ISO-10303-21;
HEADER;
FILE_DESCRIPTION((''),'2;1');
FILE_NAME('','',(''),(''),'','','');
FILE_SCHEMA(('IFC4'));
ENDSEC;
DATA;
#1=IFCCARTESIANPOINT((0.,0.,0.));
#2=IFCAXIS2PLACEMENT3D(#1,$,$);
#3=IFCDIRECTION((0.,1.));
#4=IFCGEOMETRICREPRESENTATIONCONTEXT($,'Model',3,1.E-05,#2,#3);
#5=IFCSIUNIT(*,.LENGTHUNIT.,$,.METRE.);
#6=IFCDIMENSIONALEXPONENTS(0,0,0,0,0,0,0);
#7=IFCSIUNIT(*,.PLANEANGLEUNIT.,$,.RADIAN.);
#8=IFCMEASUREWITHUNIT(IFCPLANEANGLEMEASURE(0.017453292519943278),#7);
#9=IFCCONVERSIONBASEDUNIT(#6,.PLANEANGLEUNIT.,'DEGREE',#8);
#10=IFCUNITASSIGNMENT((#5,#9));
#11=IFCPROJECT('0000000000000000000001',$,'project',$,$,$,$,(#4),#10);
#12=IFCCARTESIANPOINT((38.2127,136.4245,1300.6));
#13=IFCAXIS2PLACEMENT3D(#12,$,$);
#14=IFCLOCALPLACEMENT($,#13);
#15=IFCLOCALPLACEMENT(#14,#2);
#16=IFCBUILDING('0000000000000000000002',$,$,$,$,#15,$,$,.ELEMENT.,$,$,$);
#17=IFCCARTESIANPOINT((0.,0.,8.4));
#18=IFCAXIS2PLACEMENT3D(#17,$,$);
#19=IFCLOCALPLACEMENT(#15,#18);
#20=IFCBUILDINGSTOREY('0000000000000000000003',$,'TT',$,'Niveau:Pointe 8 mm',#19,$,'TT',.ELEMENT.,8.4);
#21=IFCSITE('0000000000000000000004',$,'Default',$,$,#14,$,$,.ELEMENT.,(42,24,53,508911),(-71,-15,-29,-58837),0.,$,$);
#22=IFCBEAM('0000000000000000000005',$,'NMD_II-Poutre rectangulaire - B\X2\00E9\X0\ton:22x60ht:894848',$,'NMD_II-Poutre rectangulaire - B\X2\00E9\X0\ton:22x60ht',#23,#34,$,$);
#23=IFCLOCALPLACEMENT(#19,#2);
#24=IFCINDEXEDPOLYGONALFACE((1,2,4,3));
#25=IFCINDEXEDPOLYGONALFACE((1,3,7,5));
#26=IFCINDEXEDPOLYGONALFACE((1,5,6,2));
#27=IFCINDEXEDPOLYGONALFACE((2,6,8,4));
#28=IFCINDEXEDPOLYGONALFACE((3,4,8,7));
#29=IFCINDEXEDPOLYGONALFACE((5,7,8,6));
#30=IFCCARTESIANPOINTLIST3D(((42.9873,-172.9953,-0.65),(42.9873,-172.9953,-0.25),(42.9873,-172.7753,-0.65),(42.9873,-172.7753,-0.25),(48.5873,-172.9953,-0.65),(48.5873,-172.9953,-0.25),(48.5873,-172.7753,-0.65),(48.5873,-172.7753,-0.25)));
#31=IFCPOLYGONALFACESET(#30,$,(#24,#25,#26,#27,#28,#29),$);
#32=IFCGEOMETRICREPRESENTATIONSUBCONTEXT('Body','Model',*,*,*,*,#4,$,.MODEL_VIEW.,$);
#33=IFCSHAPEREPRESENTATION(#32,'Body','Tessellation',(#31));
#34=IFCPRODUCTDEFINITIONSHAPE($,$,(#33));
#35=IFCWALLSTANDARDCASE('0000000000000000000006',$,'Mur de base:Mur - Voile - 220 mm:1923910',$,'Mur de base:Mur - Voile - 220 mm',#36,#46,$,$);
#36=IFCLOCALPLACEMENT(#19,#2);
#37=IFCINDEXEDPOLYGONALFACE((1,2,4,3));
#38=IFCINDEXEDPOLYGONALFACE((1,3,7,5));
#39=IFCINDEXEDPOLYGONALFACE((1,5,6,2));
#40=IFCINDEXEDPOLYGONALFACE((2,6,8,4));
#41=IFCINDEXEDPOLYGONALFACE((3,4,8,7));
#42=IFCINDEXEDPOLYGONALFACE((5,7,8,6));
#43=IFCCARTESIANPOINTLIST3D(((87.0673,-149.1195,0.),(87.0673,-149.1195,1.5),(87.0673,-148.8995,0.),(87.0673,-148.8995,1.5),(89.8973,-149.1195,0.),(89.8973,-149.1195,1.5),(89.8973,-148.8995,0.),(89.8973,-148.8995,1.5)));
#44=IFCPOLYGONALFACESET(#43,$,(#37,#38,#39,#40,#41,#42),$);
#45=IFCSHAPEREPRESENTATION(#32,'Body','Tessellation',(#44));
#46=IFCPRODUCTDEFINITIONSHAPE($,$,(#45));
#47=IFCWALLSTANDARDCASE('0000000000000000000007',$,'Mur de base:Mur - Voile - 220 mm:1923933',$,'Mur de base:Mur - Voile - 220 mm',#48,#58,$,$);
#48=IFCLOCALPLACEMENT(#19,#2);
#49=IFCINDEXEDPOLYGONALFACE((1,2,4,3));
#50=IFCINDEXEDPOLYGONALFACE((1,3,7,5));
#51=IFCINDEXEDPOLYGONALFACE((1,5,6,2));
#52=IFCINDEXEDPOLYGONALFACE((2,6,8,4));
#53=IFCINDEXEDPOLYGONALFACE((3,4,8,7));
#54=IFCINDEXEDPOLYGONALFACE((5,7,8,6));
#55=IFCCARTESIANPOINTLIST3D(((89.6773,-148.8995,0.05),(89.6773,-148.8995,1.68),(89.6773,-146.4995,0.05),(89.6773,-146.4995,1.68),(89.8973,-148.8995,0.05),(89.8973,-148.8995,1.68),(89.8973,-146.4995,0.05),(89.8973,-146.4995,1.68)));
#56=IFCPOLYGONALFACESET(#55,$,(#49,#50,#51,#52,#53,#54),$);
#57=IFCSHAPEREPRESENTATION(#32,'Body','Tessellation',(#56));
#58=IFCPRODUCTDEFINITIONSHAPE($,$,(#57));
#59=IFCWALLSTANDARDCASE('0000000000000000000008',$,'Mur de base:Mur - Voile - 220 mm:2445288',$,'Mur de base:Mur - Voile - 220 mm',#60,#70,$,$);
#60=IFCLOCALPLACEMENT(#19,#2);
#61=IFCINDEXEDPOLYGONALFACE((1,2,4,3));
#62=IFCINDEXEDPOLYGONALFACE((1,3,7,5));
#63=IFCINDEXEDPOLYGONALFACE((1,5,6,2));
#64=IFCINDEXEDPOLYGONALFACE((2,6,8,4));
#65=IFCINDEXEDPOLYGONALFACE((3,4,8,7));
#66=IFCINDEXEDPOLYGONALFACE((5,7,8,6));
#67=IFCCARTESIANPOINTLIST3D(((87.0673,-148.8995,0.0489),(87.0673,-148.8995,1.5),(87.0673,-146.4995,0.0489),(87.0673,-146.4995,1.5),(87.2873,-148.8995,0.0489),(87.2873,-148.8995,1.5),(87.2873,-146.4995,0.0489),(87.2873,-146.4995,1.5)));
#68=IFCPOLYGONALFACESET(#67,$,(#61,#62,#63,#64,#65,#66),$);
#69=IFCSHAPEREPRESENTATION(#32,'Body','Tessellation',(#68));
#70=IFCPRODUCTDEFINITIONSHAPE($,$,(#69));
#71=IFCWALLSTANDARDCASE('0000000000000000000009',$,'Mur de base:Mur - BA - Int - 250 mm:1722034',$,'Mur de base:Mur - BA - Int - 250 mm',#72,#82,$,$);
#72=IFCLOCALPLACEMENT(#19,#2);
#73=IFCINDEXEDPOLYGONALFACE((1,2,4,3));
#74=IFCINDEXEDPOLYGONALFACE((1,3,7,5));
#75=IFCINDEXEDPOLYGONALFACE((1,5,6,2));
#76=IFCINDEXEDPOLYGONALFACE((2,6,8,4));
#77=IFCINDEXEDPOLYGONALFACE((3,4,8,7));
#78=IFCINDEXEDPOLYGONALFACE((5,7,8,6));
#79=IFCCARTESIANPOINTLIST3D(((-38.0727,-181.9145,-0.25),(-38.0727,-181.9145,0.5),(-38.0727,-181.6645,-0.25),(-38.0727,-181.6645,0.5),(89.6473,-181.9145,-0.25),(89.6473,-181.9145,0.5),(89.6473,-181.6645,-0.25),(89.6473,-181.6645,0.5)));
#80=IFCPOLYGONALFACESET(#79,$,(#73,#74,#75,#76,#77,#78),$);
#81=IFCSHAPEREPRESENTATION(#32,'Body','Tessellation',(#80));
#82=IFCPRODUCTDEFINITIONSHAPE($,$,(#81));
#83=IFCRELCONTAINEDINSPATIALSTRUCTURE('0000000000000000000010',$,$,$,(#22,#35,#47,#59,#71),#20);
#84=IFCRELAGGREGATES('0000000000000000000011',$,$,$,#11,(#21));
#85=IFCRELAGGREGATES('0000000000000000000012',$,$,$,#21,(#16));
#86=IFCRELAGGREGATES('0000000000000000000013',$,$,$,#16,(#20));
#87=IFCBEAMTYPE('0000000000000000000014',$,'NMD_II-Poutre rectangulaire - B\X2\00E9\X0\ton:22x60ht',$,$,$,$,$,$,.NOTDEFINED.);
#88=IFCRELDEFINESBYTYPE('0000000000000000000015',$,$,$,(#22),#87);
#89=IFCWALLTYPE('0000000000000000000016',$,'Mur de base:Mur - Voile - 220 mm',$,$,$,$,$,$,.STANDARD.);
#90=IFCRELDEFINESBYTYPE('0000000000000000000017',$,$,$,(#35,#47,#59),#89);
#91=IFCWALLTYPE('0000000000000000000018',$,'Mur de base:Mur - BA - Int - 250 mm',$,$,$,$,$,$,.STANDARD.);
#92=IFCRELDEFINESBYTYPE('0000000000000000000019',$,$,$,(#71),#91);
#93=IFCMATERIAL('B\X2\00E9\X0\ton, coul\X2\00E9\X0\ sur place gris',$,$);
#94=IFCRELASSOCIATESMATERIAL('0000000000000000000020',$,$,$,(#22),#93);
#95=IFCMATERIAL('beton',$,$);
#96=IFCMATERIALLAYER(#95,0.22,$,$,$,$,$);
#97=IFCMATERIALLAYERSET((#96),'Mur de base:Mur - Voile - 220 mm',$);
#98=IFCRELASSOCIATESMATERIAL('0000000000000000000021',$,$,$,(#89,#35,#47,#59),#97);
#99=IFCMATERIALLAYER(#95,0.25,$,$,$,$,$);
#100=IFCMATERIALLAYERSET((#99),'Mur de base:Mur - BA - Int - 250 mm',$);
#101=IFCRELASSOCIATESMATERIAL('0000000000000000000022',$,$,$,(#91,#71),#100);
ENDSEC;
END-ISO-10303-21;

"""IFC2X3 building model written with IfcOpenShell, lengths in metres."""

from ifc_helpers import new_model, entity, si_unit, converted_unit, direction, frame, frame_2d, origin, origin_2d_with_axis, place, context, subcontext, project, spatial, polyline, rectangle, extrude, clip, bounded_halfspace, material, layer, layer_set, layer_usage, type_object, element, save


model = new_model("IFC2X3")

# Units and contexts
model_context = context("Model", 3, precision=1e-05, world=origin(), true_north=direction((0.0, 1.0)))
body_context = subcontext(model_context, "Body", "Model", "MODEL_VIEW")
ifc_project = project(units=[si_unit("LENGTHUNIT", "METRE"), converted_unit("PLANEANGLEUNIT", "DEGREE", entity("IfcPlaneAngleMeasure", 0.017453292519943278), si_unit("PLANEANGLEUNIT", "RADIAN"), dimensions=[0, 0, 0, 0, 0, 0, 0])], contexts=[model_context])

# Site, building, storey
site_placement = place(None, frame((38.2127, 136.4245, 1300.6)))
site = spatial("IfcSite", under=ifc_project, at=site_placement, Name="Default", CompositionType="ELEMENT", RefLatitude=(42, 24, 53, 508911), RefLongitude=(-71, -15, -29, -58837), RefElevation=0.0)
building_placement = place(site_placement, origin())
building = spatial("IfcBuilding", under=site, at=building_placement, CompositionType="ELEMENT")
storey_placement = place(building_placement, frame((0.0, 0.0, 8.4)))
storey = spatial("IfcBuildingStorey", under=building, at=storey_placement, Name="TT", ObjectType="Niveau:Pointe 8 mm", LongName="TT", CompositionType="ELEMENT", Elevation=8.4)

# Beam
ifc_material_1 = material(Name="Béton, coulé sur place gris")
beam_type_1 = type_object("IfcBeamType", Name="NMD_II-Poutre rectangulaire - Béton:22x60ht", PredefinedType="NOTDEFINED")
beam_1_placement = place(storey_placement, frame((42.9873, -172.8853, -0.05)))
element("IfcBeam", 1, at=beam_1_placement, inside=storey, type_object=beam_type_1, material=ifc_material_1, Name="NMD_II-Poutre rectangulaire - Béton:22x60ht:894848", ObjectType="NMD_II-Poutre rectangulaire - Béton:22x60ht", context=body_context, shape_type="SweptSolid", body=[
    extrude(rectangle(XDim=0.4, YDim=0.22, at=origin_2d_with_axis()), frame((0.0, 0.0, -0.4), z_axis=(1.0, 0.0, 0.0), x_axis=(0.0, 0.0, -1.0)), (0.0, 0.0, 1.0), 5.6),
])

# Walls
ifc_material_2 = material(Name="beton")
ifc_layer_1 = layer(ifc_material_2, 0.22)
ifc_layer_set_1 = layer_set([ifc_layer_1], Name="Mur de base:Mur - Voile - 220 mm")
ifc_layer_usage_1 = layer_usage(ifc_layer_set_1, "AXIS2", "NEGATIVE", 0.11)
wall_type_1 = type_object("IfcWallType", Name="Mur de base:Mur - Voile - 220 mm", PredefinedType="STANDARD", material=ifc_layer_set_1)
wall_1_placement = place(storey_placement, frame((89.8973, -149.0095, 0.0), z_axis=(0.0, 0.0, 1.0), x_axis=(-1.0, 0.0, 0.0)))
element("IfcWallStandardCase", 2, at=wall_1_placement, inside=storey, type_object=wall_type_1, material=ifc_layer_usage_1, Name="Mur de base:Mur - Voile - 220 mm:1923910", ObjectType="Mur de base:Mur - Voile - 220 mm", context=body_context, shape_type="SweptSolid", body=[
    extrude(rectangle(XDim=2.83, YDim=0.22, at=frame_2d((1.415, 0.0), x_axis=(-1.0, 0.0))), origin(), (0.0, 0.0, 1.0), 1.5),
])
ifc_layer_usage_2 = layer_usage(ifc_layer_set_1, "AXIS2", "NEGATIVE", 0.11)
wall_2_placement = place(storey_placement, frame((89.7873, -146.4995, 0.05), z_axis=(0.0, 0.0, 1.0), x_axis=(0.0, -1.0, 0.0)))
element("IfcWallStandardCase", 3, at=wall_2_placement, inside=storey, type_object=wall_type_1, material=ifc_layer_usage_2, Name="Mur de base:Mur - Voile - 220 mm:1923933", ObjectType="Mur de base:Mur - Voile - 220 mm", context=body_context, shape_type="Clipping", body=[
    clip(extrude(rectangle(XDim=2.4, YDim=0.22, at=frame_2d((1.2, 0.0), x_axis=(-1.0, 0.0))), origin(), (0.0, 0.0, 1.0), 1.63), bounded_halfspace(frame((0.0, -0.11, 1.63), z_axis=(0.0, 0.0, -1.0), x_axis=(1.0, 0.0, 0.0)), True, frame((0.0, -0.11, 1.63)), polyline([(0.0, 0.0), (2.4, 0.0), (2.4, 0.22), (0.0, 0.22), (0.0, 0.0)]))),
])
ifc_layer_usage_3 = layer_usage(ifc_layer_set_1, "AXIS2", "NEGATIVE", 0.11)
wall_3_placement = place(storey_placement, frame((87.1773, -146.4995, 0.0489), z_axis=(0.0, 0.0, 1.0), x_axis=(0.0, -1.0, 0.0)))
element("IfcWallStandardCase", 4, at=wall_3_placement, inside=storey, type_object=wall_type_1, material=ifc_layer_usage_3, Name="Mur de base:Mur - Voile - 220 mm:2445288", ObjectType="Mur de base:Mur - Voile - 220 mm", context=body_context, shape_type="SweptSolid", body=[
    extrude(rectangle(XDim=2.4, YDim=0.22, at=frame_2d((1.2, 0.0), x_axis=(-1.0, 0.0))), origin(), (0.0, 0.0, 1.0), 1.4511),
])
ifc_layer_2 = layer(ifc_material_2, 0.25)
ifc_layer_set_2 = layer_set([ifc_layer_2], Name="Mur de base:Mur - BA - Int - 250 mm")
ifc_layer_usage_4 = layer_usage(ifc_layer_set_2, "AXIS2", "NEGATIVE", 0.125)
wall_type_2 = type_object("IfcWallType", Name="Mur de base:Mur - BA - Int - 250 mm", PredefinedType="STANDARD", material=ifc_layer_set_2)
wall_4_placement = place(storey_placement, frame((89.6473, -181.7895, -0.25), z_axis=(0.0, 0.0, 1.0), x_axis=(-1.0, 0.0, 0.0)))
element("IfcWallStandardCase", 5, at=wall_4_placement, inside=storey, type_object=wall_type_2, material=ifc_layer_usage_4, Name="Mur de base:Mur - BA - Int - 250 mm:1722034", ObjectType="Mur de base:Mur - BA - Int - 250 mm", context=body_context, shape_type="SweptSolid", body=[
    extrude(rectangle(XDim=127.72, YDim=0.25, at=frame_2d((63.86, 0.0), x_axis=(-1.0, 0.0))), origin(), (0.0, 0.0, 1.0), 0.75),
])

save(model, "model.ifc")
